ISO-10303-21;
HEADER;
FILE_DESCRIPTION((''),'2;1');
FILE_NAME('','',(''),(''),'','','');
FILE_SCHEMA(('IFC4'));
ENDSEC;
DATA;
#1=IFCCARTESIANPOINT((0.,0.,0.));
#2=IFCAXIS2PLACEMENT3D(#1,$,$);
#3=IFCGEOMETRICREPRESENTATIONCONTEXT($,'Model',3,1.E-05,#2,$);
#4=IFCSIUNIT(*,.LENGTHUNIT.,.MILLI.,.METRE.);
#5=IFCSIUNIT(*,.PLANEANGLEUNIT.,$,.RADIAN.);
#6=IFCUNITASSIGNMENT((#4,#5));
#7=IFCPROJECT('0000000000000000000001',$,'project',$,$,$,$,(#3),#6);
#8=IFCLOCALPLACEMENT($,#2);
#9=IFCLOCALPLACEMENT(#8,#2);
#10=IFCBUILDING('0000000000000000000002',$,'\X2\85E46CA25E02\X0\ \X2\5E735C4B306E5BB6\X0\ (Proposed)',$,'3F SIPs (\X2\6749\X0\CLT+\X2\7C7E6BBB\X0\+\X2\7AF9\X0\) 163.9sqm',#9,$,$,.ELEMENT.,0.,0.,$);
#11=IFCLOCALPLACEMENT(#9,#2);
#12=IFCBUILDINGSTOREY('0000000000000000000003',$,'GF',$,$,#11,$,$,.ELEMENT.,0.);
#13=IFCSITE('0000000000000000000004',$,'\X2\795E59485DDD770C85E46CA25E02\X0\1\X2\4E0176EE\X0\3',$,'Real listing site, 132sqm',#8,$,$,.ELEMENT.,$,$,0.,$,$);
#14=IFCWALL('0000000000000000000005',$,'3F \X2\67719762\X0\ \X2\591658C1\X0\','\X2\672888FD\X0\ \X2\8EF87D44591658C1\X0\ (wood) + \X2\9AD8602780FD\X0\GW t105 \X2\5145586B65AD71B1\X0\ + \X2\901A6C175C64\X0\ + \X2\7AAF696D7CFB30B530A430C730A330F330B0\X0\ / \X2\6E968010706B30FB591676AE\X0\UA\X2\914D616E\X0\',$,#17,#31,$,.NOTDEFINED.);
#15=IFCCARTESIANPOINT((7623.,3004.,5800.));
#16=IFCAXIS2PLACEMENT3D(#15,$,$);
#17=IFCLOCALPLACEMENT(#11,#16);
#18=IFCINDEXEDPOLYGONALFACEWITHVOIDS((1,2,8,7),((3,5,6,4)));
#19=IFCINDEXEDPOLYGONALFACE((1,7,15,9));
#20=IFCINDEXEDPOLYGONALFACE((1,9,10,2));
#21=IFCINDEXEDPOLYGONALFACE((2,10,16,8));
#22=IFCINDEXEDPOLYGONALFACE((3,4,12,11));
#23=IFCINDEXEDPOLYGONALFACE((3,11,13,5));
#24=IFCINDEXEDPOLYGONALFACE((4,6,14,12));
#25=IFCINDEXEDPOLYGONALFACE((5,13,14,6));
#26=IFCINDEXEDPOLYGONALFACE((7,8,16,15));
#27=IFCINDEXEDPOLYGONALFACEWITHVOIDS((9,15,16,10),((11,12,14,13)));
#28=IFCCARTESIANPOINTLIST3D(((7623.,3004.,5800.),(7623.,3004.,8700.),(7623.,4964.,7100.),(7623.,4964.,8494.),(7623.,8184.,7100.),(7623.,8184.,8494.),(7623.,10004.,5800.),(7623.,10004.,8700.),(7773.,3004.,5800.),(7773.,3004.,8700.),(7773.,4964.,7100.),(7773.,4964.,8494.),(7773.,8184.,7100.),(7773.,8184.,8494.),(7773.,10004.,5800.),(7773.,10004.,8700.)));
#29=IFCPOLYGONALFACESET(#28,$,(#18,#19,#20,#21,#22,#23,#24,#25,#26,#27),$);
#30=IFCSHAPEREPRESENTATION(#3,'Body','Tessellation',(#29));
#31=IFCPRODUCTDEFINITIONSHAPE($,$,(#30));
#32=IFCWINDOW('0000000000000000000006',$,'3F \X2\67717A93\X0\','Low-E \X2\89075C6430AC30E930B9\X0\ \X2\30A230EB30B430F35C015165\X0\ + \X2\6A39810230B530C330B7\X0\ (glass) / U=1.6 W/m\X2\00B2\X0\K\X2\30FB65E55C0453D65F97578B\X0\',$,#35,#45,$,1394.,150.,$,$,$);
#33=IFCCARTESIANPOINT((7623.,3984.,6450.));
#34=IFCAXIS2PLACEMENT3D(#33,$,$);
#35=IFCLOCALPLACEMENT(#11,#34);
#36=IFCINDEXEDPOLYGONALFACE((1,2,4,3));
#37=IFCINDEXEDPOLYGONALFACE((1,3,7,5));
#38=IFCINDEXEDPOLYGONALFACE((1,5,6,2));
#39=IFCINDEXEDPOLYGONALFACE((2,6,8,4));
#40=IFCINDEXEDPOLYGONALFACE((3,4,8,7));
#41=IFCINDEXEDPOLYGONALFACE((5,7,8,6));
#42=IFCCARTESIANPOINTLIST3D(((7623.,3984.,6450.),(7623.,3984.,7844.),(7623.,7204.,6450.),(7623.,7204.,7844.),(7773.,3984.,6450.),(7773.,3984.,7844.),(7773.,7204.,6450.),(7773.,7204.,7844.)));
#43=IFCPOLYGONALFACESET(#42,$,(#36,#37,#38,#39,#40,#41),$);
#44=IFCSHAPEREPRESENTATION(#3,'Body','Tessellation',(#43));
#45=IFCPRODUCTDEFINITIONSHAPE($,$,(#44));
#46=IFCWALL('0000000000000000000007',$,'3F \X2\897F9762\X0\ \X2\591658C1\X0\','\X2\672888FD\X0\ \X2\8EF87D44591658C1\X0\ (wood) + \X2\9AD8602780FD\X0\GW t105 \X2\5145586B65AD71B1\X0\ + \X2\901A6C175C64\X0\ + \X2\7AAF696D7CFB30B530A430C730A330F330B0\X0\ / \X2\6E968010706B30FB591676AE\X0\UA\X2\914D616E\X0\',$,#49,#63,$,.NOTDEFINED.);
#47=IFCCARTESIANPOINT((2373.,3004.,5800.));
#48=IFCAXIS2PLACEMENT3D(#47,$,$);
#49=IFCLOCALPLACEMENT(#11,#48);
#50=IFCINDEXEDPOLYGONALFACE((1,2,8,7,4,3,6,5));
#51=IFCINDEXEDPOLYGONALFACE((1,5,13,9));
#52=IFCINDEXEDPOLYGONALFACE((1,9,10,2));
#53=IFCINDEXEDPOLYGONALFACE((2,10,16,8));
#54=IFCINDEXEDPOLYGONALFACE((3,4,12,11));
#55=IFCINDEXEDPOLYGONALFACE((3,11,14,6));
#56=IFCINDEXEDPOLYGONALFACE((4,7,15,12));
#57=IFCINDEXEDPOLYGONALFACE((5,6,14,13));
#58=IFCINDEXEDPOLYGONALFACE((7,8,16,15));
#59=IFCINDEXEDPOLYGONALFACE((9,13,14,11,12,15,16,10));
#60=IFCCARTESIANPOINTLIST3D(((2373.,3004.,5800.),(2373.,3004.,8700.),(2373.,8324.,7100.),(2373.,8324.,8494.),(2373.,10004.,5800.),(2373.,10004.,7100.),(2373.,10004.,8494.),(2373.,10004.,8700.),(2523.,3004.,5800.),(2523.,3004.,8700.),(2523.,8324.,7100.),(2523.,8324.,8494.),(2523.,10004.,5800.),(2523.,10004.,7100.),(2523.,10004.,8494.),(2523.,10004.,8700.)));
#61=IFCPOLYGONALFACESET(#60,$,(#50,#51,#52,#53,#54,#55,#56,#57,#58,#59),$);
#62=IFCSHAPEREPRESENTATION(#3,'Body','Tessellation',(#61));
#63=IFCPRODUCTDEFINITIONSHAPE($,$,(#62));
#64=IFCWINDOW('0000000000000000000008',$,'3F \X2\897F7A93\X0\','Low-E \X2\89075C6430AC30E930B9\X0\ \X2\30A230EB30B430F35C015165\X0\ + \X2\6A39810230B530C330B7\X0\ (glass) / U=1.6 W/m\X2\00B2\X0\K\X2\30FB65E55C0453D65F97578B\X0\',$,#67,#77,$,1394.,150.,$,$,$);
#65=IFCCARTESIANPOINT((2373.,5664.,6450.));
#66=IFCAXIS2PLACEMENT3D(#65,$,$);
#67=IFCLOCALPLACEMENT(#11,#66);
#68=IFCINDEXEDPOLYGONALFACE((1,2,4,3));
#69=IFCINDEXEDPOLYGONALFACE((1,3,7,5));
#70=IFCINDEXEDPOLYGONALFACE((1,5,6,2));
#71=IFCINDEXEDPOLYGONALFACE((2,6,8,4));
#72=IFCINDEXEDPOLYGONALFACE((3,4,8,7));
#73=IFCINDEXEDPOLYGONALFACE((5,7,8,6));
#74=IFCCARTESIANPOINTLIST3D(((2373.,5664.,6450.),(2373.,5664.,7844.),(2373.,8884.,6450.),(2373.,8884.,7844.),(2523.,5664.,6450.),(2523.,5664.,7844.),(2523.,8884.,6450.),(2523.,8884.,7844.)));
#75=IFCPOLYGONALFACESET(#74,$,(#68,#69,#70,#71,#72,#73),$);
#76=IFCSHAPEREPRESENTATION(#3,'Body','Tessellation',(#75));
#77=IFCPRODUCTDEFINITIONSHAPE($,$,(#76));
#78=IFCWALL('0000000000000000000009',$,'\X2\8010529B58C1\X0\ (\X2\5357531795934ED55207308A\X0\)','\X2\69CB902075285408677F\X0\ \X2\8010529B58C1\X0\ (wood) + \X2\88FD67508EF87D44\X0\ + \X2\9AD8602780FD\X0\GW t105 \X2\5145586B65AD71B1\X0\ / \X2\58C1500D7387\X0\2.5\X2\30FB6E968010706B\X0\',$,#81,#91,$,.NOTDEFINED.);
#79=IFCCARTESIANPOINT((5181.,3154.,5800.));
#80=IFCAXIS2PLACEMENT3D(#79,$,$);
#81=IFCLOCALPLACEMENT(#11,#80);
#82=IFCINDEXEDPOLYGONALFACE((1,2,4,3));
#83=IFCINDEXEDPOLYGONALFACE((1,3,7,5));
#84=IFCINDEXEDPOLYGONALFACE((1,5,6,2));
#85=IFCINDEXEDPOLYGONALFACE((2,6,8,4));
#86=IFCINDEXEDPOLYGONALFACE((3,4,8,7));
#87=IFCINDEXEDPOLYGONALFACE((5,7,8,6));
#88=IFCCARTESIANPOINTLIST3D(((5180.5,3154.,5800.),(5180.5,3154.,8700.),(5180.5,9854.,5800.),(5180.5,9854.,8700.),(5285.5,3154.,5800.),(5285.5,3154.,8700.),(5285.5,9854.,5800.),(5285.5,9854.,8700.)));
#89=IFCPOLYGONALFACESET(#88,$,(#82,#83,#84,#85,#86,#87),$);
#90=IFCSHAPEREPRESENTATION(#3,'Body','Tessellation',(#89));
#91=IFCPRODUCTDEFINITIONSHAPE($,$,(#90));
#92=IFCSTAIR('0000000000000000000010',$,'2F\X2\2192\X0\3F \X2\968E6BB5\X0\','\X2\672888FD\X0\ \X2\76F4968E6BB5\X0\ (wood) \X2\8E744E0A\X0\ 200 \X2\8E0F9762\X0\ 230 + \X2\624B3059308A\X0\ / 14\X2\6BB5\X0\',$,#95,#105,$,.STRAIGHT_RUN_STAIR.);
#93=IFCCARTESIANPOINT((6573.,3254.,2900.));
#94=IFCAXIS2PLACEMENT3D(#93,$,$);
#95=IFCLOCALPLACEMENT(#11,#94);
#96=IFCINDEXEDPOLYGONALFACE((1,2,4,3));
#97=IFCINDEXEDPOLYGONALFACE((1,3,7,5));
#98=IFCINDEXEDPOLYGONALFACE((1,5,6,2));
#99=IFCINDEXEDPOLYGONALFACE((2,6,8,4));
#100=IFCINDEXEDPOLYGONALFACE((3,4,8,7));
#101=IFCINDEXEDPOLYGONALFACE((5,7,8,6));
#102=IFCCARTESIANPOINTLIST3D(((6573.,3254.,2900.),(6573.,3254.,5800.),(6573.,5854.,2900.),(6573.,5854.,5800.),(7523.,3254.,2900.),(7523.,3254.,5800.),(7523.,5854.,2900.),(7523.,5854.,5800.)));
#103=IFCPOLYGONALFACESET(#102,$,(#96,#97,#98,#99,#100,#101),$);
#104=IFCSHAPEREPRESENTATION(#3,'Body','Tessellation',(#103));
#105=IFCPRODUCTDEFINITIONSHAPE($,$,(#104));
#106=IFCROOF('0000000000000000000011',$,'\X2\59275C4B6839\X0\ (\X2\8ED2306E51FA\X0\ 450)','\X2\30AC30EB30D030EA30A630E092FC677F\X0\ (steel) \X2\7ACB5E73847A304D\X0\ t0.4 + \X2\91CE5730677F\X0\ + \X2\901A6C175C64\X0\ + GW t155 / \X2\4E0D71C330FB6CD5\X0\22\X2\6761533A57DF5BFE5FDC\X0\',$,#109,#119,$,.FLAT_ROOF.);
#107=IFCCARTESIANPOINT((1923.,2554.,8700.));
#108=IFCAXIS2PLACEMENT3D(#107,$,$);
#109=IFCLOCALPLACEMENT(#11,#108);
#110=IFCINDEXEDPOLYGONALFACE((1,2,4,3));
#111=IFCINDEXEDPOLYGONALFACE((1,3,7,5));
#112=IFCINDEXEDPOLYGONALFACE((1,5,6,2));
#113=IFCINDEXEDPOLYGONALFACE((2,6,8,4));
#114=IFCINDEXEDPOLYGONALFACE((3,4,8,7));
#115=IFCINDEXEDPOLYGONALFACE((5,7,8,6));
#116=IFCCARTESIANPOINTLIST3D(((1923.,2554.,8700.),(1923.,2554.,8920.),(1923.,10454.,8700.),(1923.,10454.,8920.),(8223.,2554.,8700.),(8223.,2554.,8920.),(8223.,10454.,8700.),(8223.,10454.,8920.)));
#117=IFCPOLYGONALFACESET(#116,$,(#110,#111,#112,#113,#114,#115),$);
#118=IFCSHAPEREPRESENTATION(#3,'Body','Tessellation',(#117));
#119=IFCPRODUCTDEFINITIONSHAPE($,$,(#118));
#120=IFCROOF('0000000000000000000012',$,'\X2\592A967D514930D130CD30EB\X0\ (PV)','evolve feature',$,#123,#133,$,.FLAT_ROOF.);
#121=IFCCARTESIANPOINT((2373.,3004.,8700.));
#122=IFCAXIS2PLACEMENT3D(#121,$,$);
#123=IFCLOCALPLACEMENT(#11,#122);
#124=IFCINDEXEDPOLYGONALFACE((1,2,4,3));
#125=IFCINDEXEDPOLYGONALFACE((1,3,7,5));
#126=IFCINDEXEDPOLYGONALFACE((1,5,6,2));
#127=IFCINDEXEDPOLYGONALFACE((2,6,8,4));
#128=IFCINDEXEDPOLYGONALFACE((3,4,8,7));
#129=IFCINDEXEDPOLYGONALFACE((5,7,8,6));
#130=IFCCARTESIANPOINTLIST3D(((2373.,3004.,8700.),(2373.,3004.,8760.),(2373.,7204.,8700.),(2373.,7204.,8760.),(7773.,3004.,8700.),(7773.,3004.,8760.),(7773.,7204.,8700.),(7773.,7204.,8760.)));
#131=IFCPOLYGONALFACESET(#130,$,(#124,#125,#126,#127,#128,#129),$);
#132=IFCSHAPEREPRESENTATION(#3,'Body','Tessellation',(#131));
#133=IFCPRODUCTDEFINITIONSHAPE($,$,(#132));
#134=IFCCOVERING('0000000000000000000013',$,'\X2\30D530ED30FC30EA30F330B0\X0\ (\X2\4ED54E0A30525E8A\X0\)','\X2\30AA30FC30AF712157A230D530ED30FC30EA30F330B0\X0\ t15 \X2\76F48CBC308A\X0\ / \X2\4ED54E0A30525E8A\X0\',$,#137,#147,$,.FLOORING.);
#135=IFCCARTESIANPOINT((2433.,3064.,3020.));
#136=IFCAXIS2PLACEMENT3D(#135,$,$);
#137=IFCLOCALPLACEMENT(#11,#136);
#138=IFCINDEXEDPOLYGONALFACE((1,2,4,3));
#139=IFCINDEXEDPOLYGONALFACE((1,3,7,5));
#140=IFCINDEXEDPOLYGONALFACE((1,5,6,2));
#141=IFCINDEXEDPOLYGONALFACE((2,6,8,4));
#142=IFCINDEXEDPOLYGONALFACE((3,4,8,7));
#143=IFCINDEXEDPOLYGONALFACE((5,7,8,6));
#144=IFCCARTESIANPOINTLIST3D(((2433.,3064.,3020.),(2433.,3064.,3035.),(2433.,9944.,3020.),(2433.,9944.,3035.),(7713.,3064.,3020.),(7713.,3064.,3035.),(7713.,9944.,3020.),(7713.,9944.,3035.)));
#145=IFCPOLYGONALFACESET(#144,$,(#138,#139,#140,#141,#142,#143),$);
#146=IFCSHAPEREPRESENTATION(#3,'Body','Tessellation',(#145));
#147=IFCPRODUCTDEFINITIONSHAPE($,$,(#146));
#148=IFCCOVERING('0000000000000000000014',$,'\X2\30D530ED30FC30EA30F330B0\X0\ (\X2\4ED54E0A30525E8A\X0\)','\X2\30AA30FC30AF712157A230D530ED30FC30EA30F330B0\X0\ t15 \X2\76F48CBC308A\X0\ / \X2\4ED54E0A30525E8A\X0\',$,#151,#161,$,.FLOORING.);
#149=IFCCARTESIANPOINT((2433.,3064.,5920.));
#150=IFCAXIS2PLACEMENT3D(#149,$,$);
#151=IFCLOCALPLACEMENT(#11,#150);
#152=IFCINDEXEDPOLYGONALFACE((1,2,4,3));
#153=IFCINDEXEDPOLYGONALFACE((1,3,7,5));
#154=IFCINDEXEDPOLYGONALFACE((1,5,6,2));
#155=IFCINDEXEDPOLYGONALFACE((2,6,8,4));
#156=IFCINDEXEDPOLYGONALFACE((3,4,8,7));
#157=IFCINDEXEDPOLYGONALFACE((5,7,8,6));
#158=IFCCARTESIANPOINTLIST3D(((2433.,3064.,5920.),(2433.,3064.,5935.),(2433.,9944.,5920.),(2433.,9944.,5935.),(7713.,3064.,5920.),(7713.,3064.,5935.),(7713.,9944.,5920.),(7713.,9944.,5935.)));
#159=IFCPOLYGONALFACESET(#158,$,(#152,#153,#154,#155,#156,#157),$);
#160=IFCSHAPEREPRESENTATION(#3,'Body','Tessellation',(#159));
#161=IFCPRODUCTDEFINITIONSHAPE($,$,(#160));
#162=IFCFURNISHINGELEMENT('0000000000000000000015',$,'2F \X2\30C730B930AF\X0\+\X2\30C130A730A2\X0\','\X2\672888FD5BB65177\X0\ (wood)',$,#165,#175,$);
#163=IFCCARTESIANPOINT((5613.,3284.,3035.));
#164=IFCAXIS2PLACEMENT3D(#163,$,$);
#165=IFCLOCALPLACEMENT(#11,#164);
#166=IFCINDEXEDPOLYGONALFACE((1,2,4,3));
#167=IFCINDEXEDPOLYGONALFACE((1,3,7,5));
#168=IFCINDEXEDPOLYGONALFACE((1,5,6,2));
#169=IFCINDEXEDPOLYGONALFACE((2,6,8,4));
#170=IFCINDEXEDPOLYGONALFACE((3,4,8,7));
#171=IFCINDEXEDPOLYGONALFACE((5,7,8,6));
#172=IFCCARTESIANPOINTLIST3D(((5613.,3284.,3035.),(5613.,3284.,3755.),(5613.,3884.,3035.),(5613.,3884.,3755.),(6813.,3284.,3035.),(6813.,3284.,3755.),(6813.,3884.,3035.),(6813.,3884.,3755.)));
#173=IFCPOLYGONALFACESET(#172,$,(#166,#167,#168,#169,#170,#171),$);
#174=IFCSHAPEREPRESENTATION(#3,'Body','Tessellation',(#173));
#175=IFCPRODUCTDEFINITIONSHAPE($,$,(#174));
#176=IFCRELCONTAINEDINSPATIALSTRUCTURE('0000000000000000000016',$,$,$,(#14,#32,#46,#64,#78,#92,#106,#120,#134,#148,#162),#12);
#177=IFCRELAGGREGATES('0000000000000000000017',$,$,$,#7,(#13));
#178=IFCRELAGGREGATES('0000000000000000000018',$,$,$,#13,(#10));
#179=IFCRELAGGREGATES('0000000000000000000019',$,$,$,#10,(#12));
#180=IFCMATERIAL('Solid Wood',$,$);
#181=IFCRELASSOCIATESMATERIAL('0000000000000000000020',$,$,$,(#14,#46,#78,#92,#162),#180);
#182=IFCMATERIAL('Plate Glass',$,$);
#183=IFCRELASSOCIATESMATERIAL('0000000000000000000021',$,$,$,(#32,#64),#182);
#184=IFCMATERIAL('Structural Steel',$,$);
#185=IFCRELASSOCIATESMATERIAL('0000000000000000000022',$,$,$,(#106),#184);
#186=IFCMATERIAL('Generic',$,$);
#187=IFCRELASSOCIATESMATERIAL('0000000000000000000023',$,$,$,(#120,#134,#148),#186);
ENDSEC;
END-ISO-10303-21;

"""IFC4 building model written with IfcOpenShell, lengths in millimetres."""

from ifc_helpers import new_model, si_unit, frame, frame_2d, origin, place, context, project, spatial, rectangle, extrude, material, element, fill, save


model = new_model("IFC4")

# Units and contexts
model_context = context("Model", 3, precision=1e-05, world=origin())
ifc_project = project(units=[si_unit("LENGTHUNIT", "METRE", prefix="MILLI"), si_unit("PLANEANGLEUNIT", "RADIAN")], contexts=[model_context])

# Site, building, storey
site_placement = place(None, origin())
site = spatial("IfcSite", under=ifc_project, at=site_placement, Name="神奈川県藤沢市1丁目3", ObjectType="Real listing site, 132sqm", CompositionType="ELEMENT", RefElevation=0.0)
building_placement = place(site_placement, origin())
building = spatial("IfcBuilding", under=site, at=building_placement, Name="藤沢市 平屋の家 (Proposed)", ObjectType="3F SIPs (杉CLT+籾殻+竹) 163.9sqm", CompositionType="ELEMENT", ElevationOfRefHeight=0.0, ElevationOfTerrain=0.0)
storey_placement = place(building_placement, origin())
storey = spatial("IfcBuildingStorey", under=building, at=storey_placement, Name="GF", CompositionType="ELEMENT", Elevation=0.0)

# Shared definitions
ifc_material_1 = material(Name="Solid Wood")

# Shared definitions
ifc_material_2 = material(Name="Plate Glass")

# Shared definitions
ifc_material_3 = material(Name="Generic")

# Walls, openings, windows
wall_1_placement = place(storey_placement, frame((7623.0, 3004.0, 5800.0)))
wall_1 = element("IfcWall", 1, at=wall_1_placement, inside=storey, material=ifc_material_1, Name="3F 東面 外壁", Description="木製 軸組外壁 (wood) + 高性能GW t105 充填断熱 + 通気層 + 窯業系サイディング / 準耐火・外皮UA配慮", PredefinedType="NOTDEFINED", context=model_context, shape_type="SweptSolid", body=[
    extrude(rectangle(XDim=150.0, YDim=7000.0, at=frame_2d((75.0, 3500.0))), frame((7623.0, 3004.0, 5800.0)), (0.0, 0.0, 1.0), 2900.0),
])
opening_1_placement = place(storey_placement, frame((7623.0, 3984.0, 6450.0)))
opening_1 = element("IfcOpeningElement", 2, at=opening_1_placement, cuts=wall_1, PredefinedType="NOTDEFINED", context=model_context, shape_type="SweptSolid", body=[
    extrude(rectangle(XDim=150.0, YDim=3220.0, at=frame_2d((75.0, 1610.0))), frame((7623.0, 3984.0, 6450.0)), (0.0, 0.0, 1.0), 1394.0),
])
window_1_placement = place(storey_placement, frame((7623.0, 3984.0, 6450.0)))
window_1 = element("IfcWindow", 3, at=window_1_placement, inside=storey, material=ifc_material_2, Name="3F 東窓", Description="Low-E 複層ガラス アルゴン封入 + 樹脂サッシ (glass) / U=1.6 W/m²K・日射取得型", OverallHeight=1394.0, OverallWidth=150.0, context=model_context, shape_type="SweptSolid", body=[
    extrude(rectangle(XDim=150.0, YDim=3220.0, at=frame_2d((75.0, 1610.0))), frame((7623.0, 3984.0, 6450.0)), (0.0, 0.0, 1.0), 1394.0),
])
fill(opening_1, window_1)
wall_2_placement = place(storey_placement, frame((2373.0, 3004.0, 5800.0)))
wall_2 = element("IfcWall", 4, at=wall_2_placement, inside=storey, material=ifc_material_1, Name="3F 西面 外壁", Description="木製 軸組外壁 (wood) + 高性能GW t105 充填断熱 + 通気層 + 窯業系サイディング / 準耐火・外皮UA配慮", PredefinedType="NOTDEFINED", context=model_context, shape_type="SweptSolid", body=[
    extrude(rectangle(XDim=150.0, YDim=7000.0, at=frame_2d((75.0, 3500.0))), frame((2373.0, 3004.0, 5800.0)), (0.0, 0.0, 1.0), 2900.0),
])
opening_2_placement = place(storey_placement, frame((2373.0, 5664.0, 6450.0)))
opening_2 = element("IfcOpeningElement", 5, at=opening_2_placement, cuts=wall_2, PredefinedType="NOTDEFINED", context=model_context, shape_type="SweptSolid", body=[
    extrude(rectangle(XDim=150.0, YDim=3220.0, at=frame_2d((75.0, 1610.0))), frame((2373.0, 5664.0, 6450.0)), (0.0, 0.0, 1.0), 1394.0),
])
window_2_placement = place(storey_placement, frame((2373.0, 5664.0, 6450.0)))
window_2 = element("IfcWindow", 6, at=window_2_placement, inside=storey, material=ifc_material_2, Name="3F 西窓", Description="Low-E 複層ガラス アルゴン封入 + 樹脂サッシ (glass) / U=1.6 W/m²K・日射取得型", OverallHeight=1394.0, OverallWidth=150.0, context=model_context, shape_type="SweptSolid", body=[
    extrude(rectangle(XDim=150.0, YDim=3220.0, at=frame_2d((75.0, 1610.0))), frame((2373.0, 5664.0, 6450.0)), (0.0, 0.0, 1.0), 1394.0),
])
fill(opening_2, window_2)

# Wall
wall_3_placement = place(storey_placement, frame((5181.0, 3154.0, 5800.0)))
element("IfcWall", 7, at=wall_3_placement, inside=storey, material=ifc_material_1, Name="耐力壁 (南北間仕切り)", Description="構造用合板 耐力壁 (wood) + 製材軸組 + 高性能GW t105 充填断熱 / 壁倍率2.5・準耐火", PredefinedType="NOTDEFINED", context=model_context, shape_type="SweptSolid", body=[
    extrude(rectangle(XDim=105.0, YDim=6700.0, at=frame_2d((52.0, 3350.0))), frame((5181.0, 3154.0, 5800.0)), (0.0, 0.0, 1.0), 2900.0),
])

# Stair
stair_placement = place(storey_placement, frame((6573.0, 3254.0, 2900.0)))
element("IfcStair", 8, at=stair_placement, inside=storey, material=ifc_material_1, Name="2F→3F 階段", Description="木製 直階段 (wood) 蹴上 200 踏面 230 + 手すり / 14段", PredefinedType="STRAIGHT_RUN_STAIR", context=model_context, shape_type="SweptSolid", body=[
    extrude(rectangle(XDim=950.0, YDim=2600.0, at=frame_2d((475.0, 1300.0))), frame((6573.0, 3254.0, 2900.0)), (0.0, 0.0, 1.0), 2900.0),
])

# Roofs
ifc_material_4 = material(Name="Structural Steel")
roof_1_placement = place(storey_placement, frame((1923.0, 2554.0, 8700.0)))
element("IfcRoof", 9, at=roof_1_placement, inside=storey, material=ifc_material_4, Name="大屋根 (軒の出 450)", Description="ガルバリウム鋼板 (steel) 立平葺き t0.4 + 野地板 + 通気層 + GW t155 / 不燃・法22条区域対応", PredefinedType="FLAT_ROOF", context=model_context, shape_type="SweptSolid", body=[
    extrude(rectangle(XDim=6300.0, YDim=7900.0, at=frame_2d((3150.0, 3950.0))), frame((1923.0, 2554.0, 8700.0)), (0.0, 0.0, 1.0), 220.0),
])
roof_2_placement = place(storey_placement, frame((2373.0, 3004.0, 8700.0)))
element("IfcRoof", 10, at=roof_2_placement, inside=storey, material=ifc_material_3, Name="太陽光パネル (PV)", Description="evolve feature", PredefinedType="FLAT_ROOF", context=model_context, shape_type="SweptSolid", body=[
    extrude(rectangle(XDim=5400.0, YDim=4200.0, at=frame_2d((2700.0, 2100.0))), frame((2373.0, 3004.0, 8700.0)), (0.0, 0.0, 1.0), 60.0),
])

# Coverings
covering_1_placement = place(storey_placement, frame((2433.0, 3064.0, 3020.0)))
element("IfcCovering", 11, at=covering_1_placement, inside=storey, material=ifc_material_3, Name="フローリング (仕上げ床)", Description="オーク無垢フローリング t15 直貼り / 仕上げ床", PredefinedType="FLOORING", context=model_context, shape_type="SweptSolid", body=[
    extrude(rectangle(XDim=5280.0, YDim=6880.0, at=frame_2d((2640.0, 3440.0))), frame((2433.0, 3064.0, 3020.0)), (0.0, 0.0, 1.0), 15.0),
])
covering_2_placement = place(storey_placement, frame((2433.0, 3064.0, 5920.0)))
element("IfcCovering", 12, at=covering_2_placement, inside=storey, material=ifc_material_3, Name="フローリング (仕上げ床)", Description="オーク無垢フローリング t15 直貼り / 仕上げ床", PredefinedType="FLOORING", context=model_context, shape_type="SweptSolid", body=[
    extrude(rectangle(XDim=5280.0, YDim=6880.0, at=frame_2d((2640.0, 3440.0))), frame((2433.0, 3064.0, 5920.0)), (0.0, 0.0, 1.0), 15.0),
])

# Furnishing element
furnishing_placement = place(storey_placement, frame((5613.0, 3284.0, 3035.0)))
element("IfcFurnishingElement", 13, at=furnishing_placement, inside=storey, material=ifc_material_1, Name="2F デスク+チェア", Description="木製家具 (wood)", context=model_context, shape_type="SweptSolid", body=[
    extrude(rectangle(XDim=1200.0, YDim=600.0, at=frame_2d((600.0, 300.0))), frame((5613.0, 3284.0, 3035.0)), (0.0, 0.0, 1.0), 720.0),
])

save(model, "model.ifc")
